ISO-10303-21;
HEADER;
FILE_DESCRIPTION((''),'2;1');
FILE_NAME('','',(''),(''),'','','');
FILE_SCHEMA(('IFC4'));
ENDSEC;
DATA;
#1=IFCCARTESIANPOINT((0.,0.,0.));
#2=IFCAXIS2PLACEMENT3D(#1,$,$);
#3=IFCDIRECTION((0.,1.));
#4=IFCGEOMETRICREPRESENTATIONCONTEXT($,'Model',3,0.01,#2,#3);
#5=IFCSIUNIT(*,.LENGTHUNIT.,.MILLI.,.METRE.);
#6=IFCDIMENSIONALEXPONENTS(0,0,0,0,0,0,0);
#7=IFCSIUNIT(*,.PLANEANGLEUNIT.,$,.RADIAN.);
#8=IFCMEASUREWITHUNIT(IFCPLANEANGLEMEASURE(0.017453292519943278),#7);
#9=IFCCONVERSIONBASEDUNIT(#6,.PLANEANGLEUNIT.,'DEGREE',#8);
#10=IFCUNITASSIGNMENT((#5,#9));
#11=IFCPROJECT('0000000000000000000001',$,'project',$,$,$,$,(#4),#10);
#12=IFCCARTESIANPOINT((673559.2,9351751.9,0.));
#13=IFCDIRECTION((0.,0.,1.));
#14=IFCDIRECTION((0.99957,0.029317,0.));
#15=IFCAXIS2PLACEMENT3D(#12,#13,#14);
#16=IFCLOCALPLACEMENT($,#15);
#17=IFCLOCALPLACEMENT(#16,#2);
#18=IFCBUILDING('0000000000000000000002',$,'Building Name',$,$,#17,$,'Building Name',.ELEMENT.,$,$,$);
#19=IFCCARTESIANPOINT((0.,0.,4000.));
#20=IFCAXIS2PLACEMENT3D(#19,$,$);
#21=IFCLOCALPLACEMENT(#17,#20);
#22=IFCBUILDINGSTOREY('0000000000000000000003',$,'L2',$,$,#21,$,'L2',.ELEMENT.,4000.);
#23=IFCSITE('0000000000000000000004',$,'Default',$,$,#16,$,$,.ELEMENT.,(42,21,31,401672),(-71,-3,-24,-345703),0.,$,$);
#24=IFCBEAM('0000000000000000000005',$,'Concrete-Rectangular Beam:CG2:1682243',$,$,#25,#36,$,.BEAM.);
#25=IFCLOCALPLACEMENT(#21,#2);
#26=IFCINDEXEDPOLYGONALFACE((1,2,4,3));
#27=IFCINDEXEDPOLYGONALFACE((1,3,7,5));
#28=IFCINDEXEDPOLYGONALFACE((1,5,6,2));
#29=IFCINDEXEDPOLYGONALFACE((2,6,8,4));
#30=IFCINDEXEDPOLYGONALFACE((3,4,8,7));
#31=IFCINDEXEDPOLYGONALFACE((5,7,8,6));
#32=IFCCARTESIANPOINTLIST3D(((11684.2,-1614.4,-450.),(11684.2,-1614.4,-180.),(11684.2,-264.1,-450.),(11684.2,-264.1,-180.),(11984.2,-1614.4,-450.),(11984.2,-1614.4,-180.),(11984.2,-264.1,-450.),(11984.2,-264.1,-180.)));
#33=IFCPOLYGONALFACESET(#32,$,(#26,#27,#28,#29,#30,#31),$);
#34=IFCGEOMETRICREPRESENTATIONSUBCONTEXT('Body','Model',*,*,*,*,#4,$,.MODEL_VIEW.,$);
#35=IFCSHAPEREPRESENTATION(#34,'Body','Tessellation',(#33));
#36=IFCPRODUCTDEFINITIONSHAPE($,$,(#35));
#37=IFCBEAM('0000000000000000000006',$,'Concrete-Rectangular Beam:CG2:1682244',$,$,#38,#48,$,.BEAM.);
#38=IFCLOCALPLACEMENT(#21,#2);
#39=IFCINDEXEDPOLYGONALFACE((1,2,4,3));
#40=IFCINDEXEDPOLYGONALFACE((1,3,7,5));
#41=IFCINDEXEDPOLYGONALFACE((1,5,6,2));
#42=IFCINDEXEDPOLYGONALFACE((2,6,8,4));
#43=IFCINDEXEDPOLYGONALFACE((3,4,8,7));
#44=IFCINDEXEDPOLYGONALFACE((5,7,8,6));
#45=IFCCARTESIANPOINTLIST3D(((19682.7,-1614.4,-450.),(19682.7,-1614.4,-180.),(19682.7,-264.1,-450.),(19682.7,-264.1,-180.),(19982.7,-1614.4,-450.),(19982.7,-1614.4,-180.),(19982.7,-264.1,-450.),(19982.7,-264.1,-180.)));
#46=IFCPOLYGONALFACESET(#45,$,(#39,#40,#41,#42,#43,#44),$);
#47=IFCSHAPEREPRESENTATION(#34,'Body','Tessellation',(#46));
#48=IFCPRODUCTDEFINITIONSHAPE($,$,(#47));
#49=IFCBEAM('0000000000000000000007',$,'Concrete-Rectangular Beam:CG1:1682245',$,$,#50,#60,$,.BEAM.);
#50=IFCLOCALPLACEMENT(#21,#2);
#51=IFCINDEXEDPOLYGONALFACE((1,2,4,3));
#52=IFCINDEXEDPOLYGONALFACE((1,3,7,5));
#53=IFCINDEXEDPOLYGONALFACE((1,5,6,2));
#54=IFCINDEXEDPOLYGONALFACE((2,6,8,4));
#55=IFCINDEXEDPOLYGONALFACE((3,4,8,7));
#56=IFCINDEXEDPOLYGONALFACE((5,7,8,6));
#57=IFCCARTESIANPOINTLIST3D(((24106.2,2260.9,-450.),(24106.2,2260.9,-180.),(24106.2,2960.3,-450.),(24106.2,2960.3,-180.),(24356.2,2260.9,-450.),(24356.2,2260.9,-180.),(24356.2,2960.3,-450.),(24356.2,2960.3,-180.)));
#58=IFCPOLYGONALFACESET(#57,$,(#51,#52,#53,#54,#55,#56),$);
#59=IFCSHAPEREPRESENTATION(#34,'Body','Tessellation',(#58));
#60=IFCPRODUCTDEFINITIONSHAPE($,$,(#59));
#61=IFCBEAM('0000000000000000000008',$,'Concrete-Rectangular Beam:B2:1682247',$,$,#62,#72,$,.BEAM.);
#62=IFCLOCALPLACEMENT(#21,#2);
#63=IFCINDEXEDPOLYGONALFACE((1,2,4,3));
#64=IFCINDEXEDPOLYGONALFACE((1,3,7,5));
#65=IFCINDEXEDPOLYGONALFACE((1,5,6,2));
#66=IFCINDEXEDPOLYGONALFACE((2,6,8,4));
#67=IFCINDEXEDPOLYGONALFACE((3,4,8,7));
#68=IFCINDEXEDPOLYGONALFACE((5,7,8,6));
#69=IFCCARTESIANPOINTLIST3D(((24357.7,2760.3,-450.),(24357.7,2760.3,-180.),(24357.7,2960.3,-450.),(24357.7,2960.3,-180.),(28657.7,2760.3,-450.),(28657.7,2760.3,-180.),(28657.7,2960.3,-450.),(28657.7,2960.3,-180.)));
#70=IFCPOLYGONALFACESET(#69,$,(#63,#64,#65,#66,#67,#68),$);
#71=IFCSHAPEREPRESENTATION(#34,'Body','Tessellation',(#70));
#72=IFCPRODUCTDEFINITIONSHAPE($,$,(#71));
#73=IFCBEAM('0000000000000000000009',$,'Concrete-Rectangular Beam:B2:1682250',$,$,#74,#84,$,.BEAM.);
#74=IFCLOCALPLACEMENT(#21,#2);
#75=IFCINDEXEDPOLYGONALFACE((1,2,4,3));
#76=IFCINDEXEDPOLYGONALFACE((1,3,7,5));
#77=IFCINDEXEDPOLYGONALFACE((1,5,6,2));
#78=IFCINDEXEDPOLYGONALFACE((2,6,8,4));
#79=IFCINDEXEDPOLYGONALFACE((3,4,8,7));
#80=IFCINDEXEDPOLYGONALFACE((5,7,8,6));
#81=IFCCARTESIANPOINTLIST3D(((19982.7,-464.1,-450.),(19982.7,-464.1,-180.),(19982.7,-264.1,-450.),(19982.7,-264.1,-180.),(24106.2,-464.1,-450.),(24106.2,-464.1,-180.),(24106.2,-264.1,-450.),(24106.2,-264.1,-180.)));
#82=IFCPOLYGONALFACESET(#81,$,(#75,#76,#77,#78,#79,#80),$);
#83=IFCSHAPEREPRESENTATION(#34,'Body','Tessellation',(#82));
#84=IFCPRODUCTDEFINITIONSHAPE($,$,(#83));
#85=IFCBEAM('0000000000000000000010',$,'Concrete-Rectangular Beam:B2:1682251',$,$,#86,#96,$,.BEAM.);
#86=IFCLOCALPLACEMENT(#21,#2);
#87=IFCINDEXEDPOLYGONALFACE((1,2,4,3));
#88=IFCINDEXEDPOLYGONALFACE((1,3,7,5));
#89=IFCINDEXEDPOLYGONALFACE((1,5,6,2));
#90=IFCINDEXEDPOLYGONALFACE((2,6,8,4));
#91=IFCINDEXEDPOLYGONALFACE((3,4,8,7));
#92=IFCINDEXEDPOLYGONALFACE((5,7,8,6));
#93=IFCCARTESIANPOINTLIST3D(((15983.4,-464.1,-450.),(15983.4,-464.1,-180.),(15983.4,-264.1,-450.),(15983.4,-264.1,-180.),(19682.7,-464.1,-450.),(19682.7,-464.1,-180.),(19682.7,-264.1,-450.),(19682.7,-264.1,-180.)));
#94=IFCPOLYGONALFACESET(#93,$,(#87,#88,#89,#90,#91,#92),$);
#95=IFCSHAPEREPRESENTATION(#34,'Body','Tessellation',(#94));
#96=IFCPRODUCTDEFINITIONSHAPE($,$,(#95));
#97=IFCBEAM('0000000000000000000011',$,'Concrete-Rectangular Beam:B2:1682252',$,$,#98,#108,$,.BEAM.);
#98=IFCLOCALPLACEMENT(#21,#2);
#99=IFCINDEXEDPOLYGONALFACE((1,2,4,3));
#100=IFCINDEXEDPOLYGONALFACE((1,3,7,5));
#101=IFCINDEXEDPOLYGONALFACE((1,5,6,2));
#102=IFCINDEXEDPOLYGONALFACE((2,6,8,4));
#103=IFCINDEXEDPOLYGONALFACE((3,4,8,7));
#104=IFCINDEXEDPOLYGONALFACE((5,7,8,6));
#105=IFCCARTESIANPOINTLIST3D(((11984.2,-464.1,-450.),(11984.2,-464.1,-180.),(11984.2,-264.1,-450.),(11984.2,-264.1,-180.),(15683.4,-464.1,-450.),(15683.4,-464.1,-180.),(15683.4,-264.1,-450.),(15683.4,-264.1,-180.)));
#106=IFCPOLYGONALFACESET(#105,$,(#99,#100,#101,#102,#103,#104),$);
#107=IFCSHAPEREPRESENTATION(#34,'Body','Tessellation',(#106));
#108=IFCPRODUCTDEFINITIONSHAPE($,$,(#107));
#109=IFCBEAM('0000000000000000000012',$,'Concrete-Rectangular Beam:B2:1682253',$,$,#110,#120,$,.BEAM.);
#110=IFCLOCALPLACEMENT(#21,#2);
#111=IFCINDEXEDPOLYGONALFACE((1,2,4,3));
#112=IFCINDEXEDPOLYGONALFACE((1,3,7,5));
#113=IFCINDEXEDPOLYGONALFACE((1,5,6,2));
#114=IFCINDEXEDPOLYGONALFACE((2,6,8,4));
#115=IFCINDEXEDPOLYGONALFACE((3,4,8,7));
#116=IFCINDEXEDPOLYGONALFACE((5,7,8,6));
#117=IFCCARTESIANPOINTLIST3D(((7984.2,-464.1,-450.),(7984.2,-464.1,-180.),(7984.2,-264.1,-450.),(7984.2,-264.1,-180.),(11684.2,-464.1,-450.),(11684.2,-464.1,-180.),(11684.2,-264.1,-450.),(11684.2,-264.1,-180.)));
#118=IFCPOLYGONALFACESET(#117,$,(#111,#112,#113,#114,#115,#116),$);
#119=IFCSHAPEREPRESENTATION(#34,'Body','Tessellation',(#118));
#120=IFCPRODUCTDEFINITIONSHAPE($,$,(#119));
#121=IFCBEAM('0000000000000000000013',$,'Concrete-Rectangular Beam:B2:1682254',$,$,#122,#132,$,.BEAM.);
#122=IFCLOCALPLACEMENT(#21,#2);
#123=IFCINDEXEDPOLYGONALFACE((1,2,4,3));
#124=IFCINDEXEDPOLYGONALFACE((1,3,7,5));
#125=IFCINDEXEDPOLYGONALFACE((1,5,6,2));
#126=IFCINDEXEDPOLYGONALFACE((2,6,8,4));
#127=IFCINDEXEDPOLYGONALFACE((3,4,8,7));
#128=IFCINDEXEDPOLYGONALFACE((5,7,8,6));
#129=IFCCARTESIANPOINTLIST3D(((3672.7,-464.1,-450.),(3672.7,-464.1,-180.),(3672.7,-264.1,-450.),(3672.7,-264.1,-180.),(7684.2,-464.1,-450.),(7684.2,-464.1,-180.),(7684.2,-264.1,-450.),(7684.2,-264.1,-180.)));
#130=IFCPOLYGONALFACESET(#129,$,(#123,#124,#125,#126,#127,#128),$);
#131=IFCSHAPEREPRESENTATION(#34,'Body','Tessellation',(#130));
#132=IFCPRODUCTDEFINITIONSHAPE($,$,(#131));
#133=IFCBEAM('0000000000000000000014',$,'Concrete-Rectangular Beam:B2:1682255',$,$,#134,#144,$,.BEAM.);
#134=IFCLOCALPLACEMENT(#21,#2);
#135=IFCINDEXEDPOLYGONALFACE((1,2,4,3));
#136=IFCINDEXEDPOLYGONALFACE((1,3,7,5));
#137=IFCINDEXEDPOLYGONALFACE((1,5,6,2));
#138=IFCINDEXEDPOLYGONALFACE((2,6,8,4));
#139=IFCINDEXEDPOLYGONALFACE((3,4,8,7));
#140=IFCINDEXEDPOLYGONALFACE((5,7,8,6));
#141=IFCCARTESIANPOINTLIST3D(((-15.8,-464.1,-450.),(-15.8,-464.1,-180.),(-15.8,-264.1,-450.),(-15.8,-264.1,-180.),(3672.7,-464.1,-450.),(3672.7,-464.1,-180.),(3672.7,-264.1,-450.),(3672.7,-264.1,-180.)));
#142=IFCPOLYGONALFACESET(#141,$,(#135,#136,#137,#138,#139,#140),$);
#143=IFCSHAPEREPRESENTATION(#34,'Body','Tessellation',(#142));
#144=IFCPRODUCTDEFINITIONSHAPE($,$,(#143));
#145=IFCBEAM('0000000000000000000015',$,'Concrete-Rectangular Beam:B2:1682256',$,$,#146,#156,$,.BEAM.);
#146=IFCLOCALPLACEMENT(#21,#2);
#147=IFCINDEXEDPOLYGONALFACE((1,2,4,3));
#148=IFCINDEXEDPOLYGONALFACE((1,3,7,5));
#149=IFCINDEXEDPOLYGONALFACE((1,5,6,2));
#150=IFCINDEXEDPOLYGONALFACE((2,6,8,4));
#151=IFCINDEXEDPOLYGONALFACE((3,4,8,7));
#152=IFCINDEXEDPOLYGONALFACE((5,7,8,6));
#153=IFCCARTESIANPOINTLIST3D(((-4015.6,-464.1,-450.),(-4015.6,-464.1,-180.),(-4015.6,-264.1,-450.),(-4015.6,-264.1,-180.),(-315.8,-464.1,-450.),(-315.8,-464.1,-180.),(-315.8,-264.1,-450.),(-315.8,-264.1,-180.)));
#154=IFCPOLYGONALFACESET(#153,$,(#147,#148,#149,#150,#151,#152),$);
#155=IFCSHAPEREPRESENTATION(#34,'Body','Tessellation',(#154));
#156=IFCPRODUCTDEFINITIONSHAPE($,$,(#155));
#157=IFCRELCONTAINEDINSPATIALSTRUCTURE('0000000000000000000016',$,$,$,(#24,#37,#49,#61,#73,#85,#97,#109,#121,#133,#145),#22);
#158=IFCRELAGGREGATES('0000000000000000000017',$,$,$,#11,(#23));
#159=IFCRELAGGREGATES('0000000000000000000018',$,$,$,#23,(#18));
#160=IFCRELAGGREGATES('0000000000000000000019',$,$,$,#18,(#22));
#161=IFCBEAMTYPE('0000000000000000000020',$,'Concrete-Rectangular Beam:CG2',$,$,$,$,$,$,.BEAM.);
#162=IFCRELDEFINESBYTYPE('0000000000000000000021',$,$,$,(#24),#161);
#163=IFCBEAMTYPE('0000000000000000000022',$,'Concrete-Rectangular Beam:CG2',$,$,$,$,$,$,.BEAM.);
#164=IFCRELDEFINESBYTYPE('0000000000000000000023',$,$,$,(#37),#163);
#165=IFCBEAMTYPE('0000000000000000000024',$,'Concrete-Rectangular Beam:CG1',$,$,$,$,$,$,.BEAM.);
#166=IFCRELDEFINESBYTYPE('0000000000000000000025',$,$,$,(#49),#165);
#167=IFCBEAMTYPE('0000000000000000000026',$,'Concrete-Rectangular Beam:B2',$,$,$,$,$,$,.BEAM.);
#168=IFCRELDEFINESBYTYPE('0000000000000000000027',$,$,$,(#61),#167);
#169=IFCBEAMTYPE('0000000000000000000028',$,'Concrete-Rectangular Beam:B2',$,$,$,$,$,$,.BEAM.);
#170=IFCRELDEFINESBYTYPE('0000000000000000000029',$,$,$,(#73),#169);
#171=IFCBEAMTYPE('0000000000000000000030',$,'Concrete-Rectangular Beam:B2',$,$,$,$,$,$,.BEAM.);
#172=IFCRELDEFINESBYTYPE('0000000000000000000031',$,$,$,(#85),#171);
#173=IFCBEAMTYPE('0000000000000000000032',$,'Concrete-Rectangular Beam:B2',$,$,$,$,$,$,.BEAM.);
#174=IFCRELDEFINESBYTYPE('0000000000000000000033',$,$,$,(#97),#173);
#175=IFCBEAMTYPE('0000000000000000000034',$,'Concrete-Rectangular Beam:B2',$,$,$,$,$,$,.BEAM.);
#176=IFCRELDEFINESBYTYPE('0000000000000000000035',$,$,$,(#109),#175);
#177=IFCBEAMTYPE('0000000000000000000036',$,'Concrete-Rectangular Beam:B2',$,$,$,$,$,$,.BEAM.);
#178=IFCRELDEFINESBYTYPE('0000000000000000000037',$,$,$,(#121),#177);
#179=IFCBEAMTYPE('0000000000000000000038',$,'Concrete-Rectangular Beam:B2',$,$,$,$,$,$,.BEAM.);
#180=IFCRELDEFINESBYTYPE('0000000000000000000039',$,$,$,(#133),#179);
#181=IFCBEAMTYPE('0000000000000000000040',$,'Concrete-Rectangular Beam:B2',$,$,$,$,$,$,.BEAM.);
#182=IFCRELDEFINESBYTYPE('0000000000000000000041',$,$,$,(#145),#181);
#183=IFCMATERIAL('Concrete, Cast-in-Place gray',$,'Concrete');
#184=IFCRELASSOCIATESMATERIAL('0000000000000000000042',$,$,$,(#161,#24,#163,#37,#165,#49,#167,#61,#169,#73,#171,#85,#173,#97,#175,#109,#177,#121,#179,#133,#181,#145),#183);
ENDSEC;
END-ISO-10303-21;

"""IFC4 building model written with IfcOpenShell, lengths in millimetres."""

from ifc_helpers import new_model, entity, si_unit, converted_unit, direction, frame, origin, place, context, subcontext, project, spatial, indexed_curve, outline, extrude, source, transform, mapped, material, type_object, type_shapes, element, save


model = new_model("IFC4")

# Units and contexts
model_context = context("Model", 3, precision=0.01, world=origin(), true_north=direction((0.0, 1.0)))
body_context = subcontext(model_context, "Body", "Model", "MODEL_VIEW")
ifc_project = project(units=[si_unit("LENGTHUNIT", "METRE", prefix="MILLI"), converted_unit("PLANEANGLEUNIT", "DEGREE", entity("IfcPlaneAngleMeasure", 0.017453292519943278), si_unit("PLANEANGLEUNIT", "RADIAN"), dimensions=[0, 0, 0, 0, 0, 0, 0])], contexts=[model_context])

# Site, building, storey
site_placement = place(None, frame((673559.2, 9351751.9, 0.0), z_axis=(0.0, 0.0, 1.0), x_axis=(0.99957, 0.029317, 0.0)))
site = spatial("IfcSite", under=ifc_project, at=site_placement, Name="Default", CompositionType="ELEMENT", RefLatitude=(42, 21, 31, 401672), RefLongitude=(-71, -3, -24, -345703), RefElevation=0.0)
building_placement = place(site_placement, origin())
building = spatial("IfcBuilding", under=site, at=building_placement, Name="Building Name", LongName="Building Name", CompositionType="ELEMENT")
storey_placement = place(building_placement, frame((0.0, 0.0, 4000.0)))
storey = spatial("IfcBuildingStorey", under=building, at=storey_placement, Name="L2", LongName="L2", CompositionType="ELEMENT", Elevation=4000.0)

# Beams
ifc_material = material(Name="Concrete, Cast-in-Place gray", Category="Concrete")
beam_type_1 = type_object("IfcBeamType", Name="Concrete-Rectangular Beam:CG2", PredefinedType="BEAM", material=ifc_material)
shared_shape_1 = source(origin(), body_context, "Body", "SweptSolid", [
    extrude(outline(indexed_curve([(-150.0, -135.0), (150.0, -135.0), (150.0, 135.0), (-150.0, 135.0), (-150.0, -135.0)], self_intersect=False)), frame((11834.2, -1614.4, 3685.0), z_axis=(0.0, 1.0, 0.0), x_axis=(-1.0, 0.0, 0.0)), (0.0, 0.0, 1.0), 1350.4),
])
type_shapes(beam_type_1, [shared_shape_1])
beam_1_placement = place(storey_placement, frame((0.0, 0.0, -4000.0)))
element("IfcBeam", 1, at=beam_1_placement, inside=storey, type_object=beam_type_1, material=ifc_material, Name="Concrete-Rectangular Beam:CG2:1682243", PredefinedType="BEAM", context=body_context, shape_type="MappedRepresentation", body=[
    mapped(shared_shape_1, transform((0.0, 0.0, 0.0), scale=1.0)),
])
beam_type_2 = type_object("IfcBeamType", Name="Concrete-Rectangular Beam:CG2", PredefinedType="BEAM", material=ifc_material)
shared_shape_2 = source(origin(), body_context, "Body", "SweptSolid", [
    extrude(outline(indexed_curve([(-150.0, -135.0), (150.0, -135.0), (150.0, 135.0), (-150.0, 135.0), (-150.0, -135.0)], self_intersect=False)), frame((19832.7, -1614.4, 3685.0), z_axis=(0.0, 1.0, 0.0), x_axis=(-1.0, 0.0, 0.0)), (0.0, 0.0, 1.0), 1350.4),
])
type_shapes(beam_type_2, [shared_shape_2])
beam_2_placement = place(storey_placement, frame((0.0, 0.0, -4000.0)))
element("IfcBeam", 2, at=beam_2_placement, inside=storey, type_object=beam_type_2, material=ifc_material, Name="Concrete-Rectangular Beam:CG2:1682244", PredefinedType="BEAM", context=body_context, shape_type="MappedRepresentation", body=[
    mapped(shared_shape_2, transform((0.0, 0.0, 0.0), scale=1.0)),
])
beam_type_3 = type_object("IfcBeamType", Name="Concrete-Rectangular Beam:CG1", PredefinedType="BEAM", material=ifc_material)
shared_shape_3 = source(origin(), body_context, "Body", "SweptSolid", [
    extrude(outline(indexed_curve([(-125.0, -135.0), (125.0, -135.0), (125.0, 135.0), (-125.0, 135.0), (-125.0, -135.0)], self_intersect=False)), frame((24231.2, 2260.9, 3685.0), z_axis=(0.0, 1.0, 0.0), x_axis=(-1.0, 0.0, 0.0)), (0.0, 0.0, 1.0), 699.4),
])
type_shapes(beam_type_3, [shared_shape_3])
beam_3_placement = place(storey_placement, frame((0.0, 0.0, -4000.0)))
element("IfcBeam", 3, at=beam_3_placement, inside=storey, type_object=beam_type_3, material=ifc_material, Name="Concrete-Rectangular Beam:CG1:1682245", PredefinedType="BEAM", context=body_context, shape_type="MappedRepresentation", body=[
    mapped(shared_shape_3, transform((0.0, 0.0, 0.0), scale=1.0)),
])
beam_type_4 = type_object("IfcBeamType", Name="Concrete-Rectangular Beam:B2", PredefinedType="BEAM", material=ifc_material)
shared_shape_4 = source(origin(), body_context, "Body", "SweptSolid", [
    extrude(outline(indexed_curve([(-135.0, -100.0), (135.0, -100.0), (135.0, 100.0), (-135.0, 100.0), (-135.0, -100.0)], self_intersect=False)), frame((24357.7, 2860.3, 3685.0), z_axis=(1.0, 0.0, 0.0), x_axis=(0.0, 0.0, -1.0)), (0.0, 0.0, 1.0), 4300.0),
])
type_shapes(beam_type_4, [shared_shape_4])
beam_4_placement = place(storey_placement, frame((0.0, 0.0, -4000.0)))
element("IfcBeam", 4, at=beam_4_placement, inside=storey, type_object=beam_type_4, material=ifc_material, Name="Concrete-Rectangular Beam:B2:1682247", PredefinedType="BEAM", context=body_context, shape_type="MappedRepresentation", body=[
    mapped(shared_shape_4, transform((0.0, 0.0, 0.0), scale=1.0)),
])
beam_type_5 = type_object("IfcBeamType", Name="Concrete-Rectangular Beam:B2", PredefinedType="BEAM", material=ifc_material)
shared_shape_5 = source(origin(), body_context, "Body", "SweptSolid", [
    extrude(outline(indexed_curve([(-135.0, -100.0), (135.0, -100.0), (135.0, 100.0), (-135.0, 100.0), (-135.0, -100.0)], self_intersect=False)), frame((24106.2, -364.1, 3685.0), z_axis=(-1.0, 0.0, 0.0), x_axis=(0.0, 0.0, -1.0)), (0.0, 0.0, 1.0), 4123.5),
])
type_shapes(beam_type_5, [shared_shape_5])
beam_5_placement = place(storey_placement, frame((0.0, 0.0, -4000.0)))
element("IfcBeam", 5, at=beam_5_placement, inside=storey, type_object=beam_type_5, material=ifc_material, Name="Concrete-Rectangular Beam:B2:1682250", PredefinedType="BEAM", context=body_context, shape_type="MappedRepresentation", body=[
    mapped(shared_shape_5, transform((0.0, 0.0, 0.0), scale=1.0)),
])
beam_type_6 = type_object("IfcBeamType", Name="Concrete-Rectangular Beam:B2", PredefinedType="BEAM", material=ifc_material)
shared_shape_6 = source(origin(), body_context, "Body", "SweptSolid", [
    extrude(outline(indexed_curve([(-135.0, -100.0), (135.0, -100.0), (135.0, 100.0), (-135.0, 100.0), (-135.0, -100.0)], self_intersect=False)), frame((19682.7, -364.1, 3685.0), z_axis=(-1.0, 0.0, 0.0), x_axis=(0.0, 0.0, -1.0)), (0.0, 0.0, 1.0), 3699.3),
])
type_shapes(beam_type_6, [shared_shape_6])
beam_6_placement = place(storey_placement, frame((0.0, 0.0, -4000.0)))
element("IfcBeam", 6, at=beam_6_placement, inside=storey, type_object=beam_type_6, material=ifc_material, Name="Concrete-Rectangular Beam:B2:1682251", PredefinedType="BEAM", context=body_context, shape_type="MappedRepresentation", body=[
    mapped(shared_shape_6, transform((0.0, 0.0, 0.0), scale=1.0)),
])
beam_type_7 = type_object("IfcBeamType", Name="Concrete-Rectangular Beam:B2", PredefinedType="BEAM", material=ifc_material)
shared_shape_7 = source(origin(), body_context, "Body", "SweptSolid", [
    extrude(outline(indexed_curve([(-135.0, -100.0), (135.0, -100.0), (135.0, 100.0), (-135.0, 100.0), (-135.0, -100.0)], self_intersect=False)), frame((11984.2, -364.1, 3685.0), z_axis=(1.0, 0.0, 0.0), x_axis=(0.0, 0.0, -1.0)), (0.0, 0.0, 1.0), 3699.3),
])
type_shapes(beam_type_7, [shared_shape_7])
beam_7_placement = place(storey_placement, frame((0.0, 0.0, -4000.0)))
element("IfcBeam", 7, at=beam_7_placement, inside=storey, type_object=beam_type_7, material=ifc_material, Name="Concrete-Rectangular Beam:B2:1682252", PredefinedType="BEAM", context=body_context, shape_type="MappedRepresentation", body=[
    mapped(shared_shape_7, transform((0.0, 0.0, 0.0), scale=1.0)),
])
beam_type_8 = type_object("IfcBeamType", Name="Concrete-Rectangular Beam:B2", PredefinedType="BEAM", material=ifc_material)
shared_shape_8 = source(origin(), body_context, "Body", "SweptSolid", [
    extrude(outline(indexed_curve([(-135.0, -100.0), (135.0, -100.0), (135.0, 100.0), (-135.0, 100.0), (-135.0, -100.0)], self_intersect=False)), frame((11684.2, -364.1, 3685.0), z_axis=(-1.0, 0.0, 0.0), x_axis=(0.0, 0.0, -1.0)), (0.0, 0.0, 1.0), 3700.0),
])
type_shapes(beam_type_8, [shared_shape_8])
beam_8_placement = place(storey_placement, frame((0.0, 0.0, -4000.0)))
element("IfcBeam", 8, at=beam_8_placement, inside=storey, type_object=beam_type_8, material=ifc_material, Name="Concrete-Rectangular Beam:B2:1682253", PredefinedType="BEAM", context=body_context, shape_type="MappedRepresentation", body=[
    mapped(shared_shape_8, transform((0.0, 0.0, 0.0), scale=1.0)),
])
beam_type_9 = type_object("IfcBeamType", Name="Concrete-Rectangular Beam:B2", PredefinedType="BEAM", material=ifc_material)
shared_shape_9 = source(origin(), body_context, "Body", "SweptSolid", [
    extrude(outline(indexed_curve([(-135.0, -100.0), (135.0, -100.0), (135.0, 100.0), (-135.0, 100.0), (-135.0, -100.0)], self_intersect=False)), frame((7684.2, -364.1, 3685.0), z_axis=(-1.0, 0.0, 0.0), x_axis=(0.0, 0.0, -1.0)), (0.0, 0.0, 1.0), 4011.4),
])
type_shapes(beam_type_9, [shared_shape_9])
beam_9_placement = place(storey_placement, frame((0.0, 0.0, -4000.0)))
element("IfcBeam", 9, at=beam_9_placement, inside=storey, type_object=beam_type_9, material=ifc_material, Name="Concrete-Rectangular Beam:B2:1682254", PredefinedType="BEAM", context=body_context, shape_type="MappedRepresentation", body=[
    mapped(shared_shape_9, transform((0.0, 0.0, 0.0), scale=1.0)),
])
beam_type_10 = type_object("IfcBeamType", Name="Concrete-Rectangular Beam:B2", PredefinedType="BEAM", material=ifc_material)
shared_shape_10 = source(origin(), body_context, "Body", "SweptSolid", [
    extrude(outline(indexed_curve([(-135.0, -100.0), (135.0, -100.0), (135.0, 100.0), (-135.0, 100.0), (-135.0, -100.0)], self_intersect=False)), frame((3672.7, -364.1, 3685.0), z_axis=(-1.0, 0.0, 0.0), x_axis=(0.0, 0.0, -1.0)), (0.0, 0.0, 1.0), 3688.6),
])
type_shapes(beam_type_10, [shared_shape_10])
beam_10_placement = place(storey_placement, frame((0.0, 0.0, -4000.0)))
element("IfcBeam", 10, at=beam_10_placement, inside=storey, type_object=beam_type_10, material=ifc_material, Name="Concrete-Rectangular Beam:B2:1682255", PredefinedType="BEAM", context=body_context, shape_type="MappedRepresentation", body=[
    mapped(shared_shape_10, transform((0.0, 0.0, 0.0), scale=1.0)),
])
beam_type_11 = type_object("IfcBeamType", Name="Concrete-Rectangular Beam:B2", PredefinedType="BEAM", material=ifc_material)
shared_shape_11 = source(origin(), body_context, "Body", "SweptSolid", [
    extrude(outline(indexed_curve([(-135.0, -100.0), (135.0, -100.0), (135.0, 100.0), (-135.0, 100.0), (-135.0, -100.0)], self_intersect=False)), frame((-315.8, -364.1, 3685.0), z_axis=(-1.0, 0.0, 0.0), x_axis=(0.0, 0.0, -1.0)), (0.0, 0.0, 1.0), 3699.7),
])
type_shapes(beam_type_11, [shared_shape_11])
beam_11_placement = place(storey_placement, frame((0.0, 0.0, -4000.0)))
element("IfcBeam", 11, at=beam_11_placement, inside=storey, type_object=beam_type_11, material=ifc_material, Name="Concrete-Rectangular Beam:B2:1682256", PredefinedType="BEAM", context=body_context, shape_type="MappedRepresentation", body=[
    mapped(shared_shape_11, transform((0.0, 0.0, 0.0), scale=1.0)),
])

save(model, "model.ifc")
